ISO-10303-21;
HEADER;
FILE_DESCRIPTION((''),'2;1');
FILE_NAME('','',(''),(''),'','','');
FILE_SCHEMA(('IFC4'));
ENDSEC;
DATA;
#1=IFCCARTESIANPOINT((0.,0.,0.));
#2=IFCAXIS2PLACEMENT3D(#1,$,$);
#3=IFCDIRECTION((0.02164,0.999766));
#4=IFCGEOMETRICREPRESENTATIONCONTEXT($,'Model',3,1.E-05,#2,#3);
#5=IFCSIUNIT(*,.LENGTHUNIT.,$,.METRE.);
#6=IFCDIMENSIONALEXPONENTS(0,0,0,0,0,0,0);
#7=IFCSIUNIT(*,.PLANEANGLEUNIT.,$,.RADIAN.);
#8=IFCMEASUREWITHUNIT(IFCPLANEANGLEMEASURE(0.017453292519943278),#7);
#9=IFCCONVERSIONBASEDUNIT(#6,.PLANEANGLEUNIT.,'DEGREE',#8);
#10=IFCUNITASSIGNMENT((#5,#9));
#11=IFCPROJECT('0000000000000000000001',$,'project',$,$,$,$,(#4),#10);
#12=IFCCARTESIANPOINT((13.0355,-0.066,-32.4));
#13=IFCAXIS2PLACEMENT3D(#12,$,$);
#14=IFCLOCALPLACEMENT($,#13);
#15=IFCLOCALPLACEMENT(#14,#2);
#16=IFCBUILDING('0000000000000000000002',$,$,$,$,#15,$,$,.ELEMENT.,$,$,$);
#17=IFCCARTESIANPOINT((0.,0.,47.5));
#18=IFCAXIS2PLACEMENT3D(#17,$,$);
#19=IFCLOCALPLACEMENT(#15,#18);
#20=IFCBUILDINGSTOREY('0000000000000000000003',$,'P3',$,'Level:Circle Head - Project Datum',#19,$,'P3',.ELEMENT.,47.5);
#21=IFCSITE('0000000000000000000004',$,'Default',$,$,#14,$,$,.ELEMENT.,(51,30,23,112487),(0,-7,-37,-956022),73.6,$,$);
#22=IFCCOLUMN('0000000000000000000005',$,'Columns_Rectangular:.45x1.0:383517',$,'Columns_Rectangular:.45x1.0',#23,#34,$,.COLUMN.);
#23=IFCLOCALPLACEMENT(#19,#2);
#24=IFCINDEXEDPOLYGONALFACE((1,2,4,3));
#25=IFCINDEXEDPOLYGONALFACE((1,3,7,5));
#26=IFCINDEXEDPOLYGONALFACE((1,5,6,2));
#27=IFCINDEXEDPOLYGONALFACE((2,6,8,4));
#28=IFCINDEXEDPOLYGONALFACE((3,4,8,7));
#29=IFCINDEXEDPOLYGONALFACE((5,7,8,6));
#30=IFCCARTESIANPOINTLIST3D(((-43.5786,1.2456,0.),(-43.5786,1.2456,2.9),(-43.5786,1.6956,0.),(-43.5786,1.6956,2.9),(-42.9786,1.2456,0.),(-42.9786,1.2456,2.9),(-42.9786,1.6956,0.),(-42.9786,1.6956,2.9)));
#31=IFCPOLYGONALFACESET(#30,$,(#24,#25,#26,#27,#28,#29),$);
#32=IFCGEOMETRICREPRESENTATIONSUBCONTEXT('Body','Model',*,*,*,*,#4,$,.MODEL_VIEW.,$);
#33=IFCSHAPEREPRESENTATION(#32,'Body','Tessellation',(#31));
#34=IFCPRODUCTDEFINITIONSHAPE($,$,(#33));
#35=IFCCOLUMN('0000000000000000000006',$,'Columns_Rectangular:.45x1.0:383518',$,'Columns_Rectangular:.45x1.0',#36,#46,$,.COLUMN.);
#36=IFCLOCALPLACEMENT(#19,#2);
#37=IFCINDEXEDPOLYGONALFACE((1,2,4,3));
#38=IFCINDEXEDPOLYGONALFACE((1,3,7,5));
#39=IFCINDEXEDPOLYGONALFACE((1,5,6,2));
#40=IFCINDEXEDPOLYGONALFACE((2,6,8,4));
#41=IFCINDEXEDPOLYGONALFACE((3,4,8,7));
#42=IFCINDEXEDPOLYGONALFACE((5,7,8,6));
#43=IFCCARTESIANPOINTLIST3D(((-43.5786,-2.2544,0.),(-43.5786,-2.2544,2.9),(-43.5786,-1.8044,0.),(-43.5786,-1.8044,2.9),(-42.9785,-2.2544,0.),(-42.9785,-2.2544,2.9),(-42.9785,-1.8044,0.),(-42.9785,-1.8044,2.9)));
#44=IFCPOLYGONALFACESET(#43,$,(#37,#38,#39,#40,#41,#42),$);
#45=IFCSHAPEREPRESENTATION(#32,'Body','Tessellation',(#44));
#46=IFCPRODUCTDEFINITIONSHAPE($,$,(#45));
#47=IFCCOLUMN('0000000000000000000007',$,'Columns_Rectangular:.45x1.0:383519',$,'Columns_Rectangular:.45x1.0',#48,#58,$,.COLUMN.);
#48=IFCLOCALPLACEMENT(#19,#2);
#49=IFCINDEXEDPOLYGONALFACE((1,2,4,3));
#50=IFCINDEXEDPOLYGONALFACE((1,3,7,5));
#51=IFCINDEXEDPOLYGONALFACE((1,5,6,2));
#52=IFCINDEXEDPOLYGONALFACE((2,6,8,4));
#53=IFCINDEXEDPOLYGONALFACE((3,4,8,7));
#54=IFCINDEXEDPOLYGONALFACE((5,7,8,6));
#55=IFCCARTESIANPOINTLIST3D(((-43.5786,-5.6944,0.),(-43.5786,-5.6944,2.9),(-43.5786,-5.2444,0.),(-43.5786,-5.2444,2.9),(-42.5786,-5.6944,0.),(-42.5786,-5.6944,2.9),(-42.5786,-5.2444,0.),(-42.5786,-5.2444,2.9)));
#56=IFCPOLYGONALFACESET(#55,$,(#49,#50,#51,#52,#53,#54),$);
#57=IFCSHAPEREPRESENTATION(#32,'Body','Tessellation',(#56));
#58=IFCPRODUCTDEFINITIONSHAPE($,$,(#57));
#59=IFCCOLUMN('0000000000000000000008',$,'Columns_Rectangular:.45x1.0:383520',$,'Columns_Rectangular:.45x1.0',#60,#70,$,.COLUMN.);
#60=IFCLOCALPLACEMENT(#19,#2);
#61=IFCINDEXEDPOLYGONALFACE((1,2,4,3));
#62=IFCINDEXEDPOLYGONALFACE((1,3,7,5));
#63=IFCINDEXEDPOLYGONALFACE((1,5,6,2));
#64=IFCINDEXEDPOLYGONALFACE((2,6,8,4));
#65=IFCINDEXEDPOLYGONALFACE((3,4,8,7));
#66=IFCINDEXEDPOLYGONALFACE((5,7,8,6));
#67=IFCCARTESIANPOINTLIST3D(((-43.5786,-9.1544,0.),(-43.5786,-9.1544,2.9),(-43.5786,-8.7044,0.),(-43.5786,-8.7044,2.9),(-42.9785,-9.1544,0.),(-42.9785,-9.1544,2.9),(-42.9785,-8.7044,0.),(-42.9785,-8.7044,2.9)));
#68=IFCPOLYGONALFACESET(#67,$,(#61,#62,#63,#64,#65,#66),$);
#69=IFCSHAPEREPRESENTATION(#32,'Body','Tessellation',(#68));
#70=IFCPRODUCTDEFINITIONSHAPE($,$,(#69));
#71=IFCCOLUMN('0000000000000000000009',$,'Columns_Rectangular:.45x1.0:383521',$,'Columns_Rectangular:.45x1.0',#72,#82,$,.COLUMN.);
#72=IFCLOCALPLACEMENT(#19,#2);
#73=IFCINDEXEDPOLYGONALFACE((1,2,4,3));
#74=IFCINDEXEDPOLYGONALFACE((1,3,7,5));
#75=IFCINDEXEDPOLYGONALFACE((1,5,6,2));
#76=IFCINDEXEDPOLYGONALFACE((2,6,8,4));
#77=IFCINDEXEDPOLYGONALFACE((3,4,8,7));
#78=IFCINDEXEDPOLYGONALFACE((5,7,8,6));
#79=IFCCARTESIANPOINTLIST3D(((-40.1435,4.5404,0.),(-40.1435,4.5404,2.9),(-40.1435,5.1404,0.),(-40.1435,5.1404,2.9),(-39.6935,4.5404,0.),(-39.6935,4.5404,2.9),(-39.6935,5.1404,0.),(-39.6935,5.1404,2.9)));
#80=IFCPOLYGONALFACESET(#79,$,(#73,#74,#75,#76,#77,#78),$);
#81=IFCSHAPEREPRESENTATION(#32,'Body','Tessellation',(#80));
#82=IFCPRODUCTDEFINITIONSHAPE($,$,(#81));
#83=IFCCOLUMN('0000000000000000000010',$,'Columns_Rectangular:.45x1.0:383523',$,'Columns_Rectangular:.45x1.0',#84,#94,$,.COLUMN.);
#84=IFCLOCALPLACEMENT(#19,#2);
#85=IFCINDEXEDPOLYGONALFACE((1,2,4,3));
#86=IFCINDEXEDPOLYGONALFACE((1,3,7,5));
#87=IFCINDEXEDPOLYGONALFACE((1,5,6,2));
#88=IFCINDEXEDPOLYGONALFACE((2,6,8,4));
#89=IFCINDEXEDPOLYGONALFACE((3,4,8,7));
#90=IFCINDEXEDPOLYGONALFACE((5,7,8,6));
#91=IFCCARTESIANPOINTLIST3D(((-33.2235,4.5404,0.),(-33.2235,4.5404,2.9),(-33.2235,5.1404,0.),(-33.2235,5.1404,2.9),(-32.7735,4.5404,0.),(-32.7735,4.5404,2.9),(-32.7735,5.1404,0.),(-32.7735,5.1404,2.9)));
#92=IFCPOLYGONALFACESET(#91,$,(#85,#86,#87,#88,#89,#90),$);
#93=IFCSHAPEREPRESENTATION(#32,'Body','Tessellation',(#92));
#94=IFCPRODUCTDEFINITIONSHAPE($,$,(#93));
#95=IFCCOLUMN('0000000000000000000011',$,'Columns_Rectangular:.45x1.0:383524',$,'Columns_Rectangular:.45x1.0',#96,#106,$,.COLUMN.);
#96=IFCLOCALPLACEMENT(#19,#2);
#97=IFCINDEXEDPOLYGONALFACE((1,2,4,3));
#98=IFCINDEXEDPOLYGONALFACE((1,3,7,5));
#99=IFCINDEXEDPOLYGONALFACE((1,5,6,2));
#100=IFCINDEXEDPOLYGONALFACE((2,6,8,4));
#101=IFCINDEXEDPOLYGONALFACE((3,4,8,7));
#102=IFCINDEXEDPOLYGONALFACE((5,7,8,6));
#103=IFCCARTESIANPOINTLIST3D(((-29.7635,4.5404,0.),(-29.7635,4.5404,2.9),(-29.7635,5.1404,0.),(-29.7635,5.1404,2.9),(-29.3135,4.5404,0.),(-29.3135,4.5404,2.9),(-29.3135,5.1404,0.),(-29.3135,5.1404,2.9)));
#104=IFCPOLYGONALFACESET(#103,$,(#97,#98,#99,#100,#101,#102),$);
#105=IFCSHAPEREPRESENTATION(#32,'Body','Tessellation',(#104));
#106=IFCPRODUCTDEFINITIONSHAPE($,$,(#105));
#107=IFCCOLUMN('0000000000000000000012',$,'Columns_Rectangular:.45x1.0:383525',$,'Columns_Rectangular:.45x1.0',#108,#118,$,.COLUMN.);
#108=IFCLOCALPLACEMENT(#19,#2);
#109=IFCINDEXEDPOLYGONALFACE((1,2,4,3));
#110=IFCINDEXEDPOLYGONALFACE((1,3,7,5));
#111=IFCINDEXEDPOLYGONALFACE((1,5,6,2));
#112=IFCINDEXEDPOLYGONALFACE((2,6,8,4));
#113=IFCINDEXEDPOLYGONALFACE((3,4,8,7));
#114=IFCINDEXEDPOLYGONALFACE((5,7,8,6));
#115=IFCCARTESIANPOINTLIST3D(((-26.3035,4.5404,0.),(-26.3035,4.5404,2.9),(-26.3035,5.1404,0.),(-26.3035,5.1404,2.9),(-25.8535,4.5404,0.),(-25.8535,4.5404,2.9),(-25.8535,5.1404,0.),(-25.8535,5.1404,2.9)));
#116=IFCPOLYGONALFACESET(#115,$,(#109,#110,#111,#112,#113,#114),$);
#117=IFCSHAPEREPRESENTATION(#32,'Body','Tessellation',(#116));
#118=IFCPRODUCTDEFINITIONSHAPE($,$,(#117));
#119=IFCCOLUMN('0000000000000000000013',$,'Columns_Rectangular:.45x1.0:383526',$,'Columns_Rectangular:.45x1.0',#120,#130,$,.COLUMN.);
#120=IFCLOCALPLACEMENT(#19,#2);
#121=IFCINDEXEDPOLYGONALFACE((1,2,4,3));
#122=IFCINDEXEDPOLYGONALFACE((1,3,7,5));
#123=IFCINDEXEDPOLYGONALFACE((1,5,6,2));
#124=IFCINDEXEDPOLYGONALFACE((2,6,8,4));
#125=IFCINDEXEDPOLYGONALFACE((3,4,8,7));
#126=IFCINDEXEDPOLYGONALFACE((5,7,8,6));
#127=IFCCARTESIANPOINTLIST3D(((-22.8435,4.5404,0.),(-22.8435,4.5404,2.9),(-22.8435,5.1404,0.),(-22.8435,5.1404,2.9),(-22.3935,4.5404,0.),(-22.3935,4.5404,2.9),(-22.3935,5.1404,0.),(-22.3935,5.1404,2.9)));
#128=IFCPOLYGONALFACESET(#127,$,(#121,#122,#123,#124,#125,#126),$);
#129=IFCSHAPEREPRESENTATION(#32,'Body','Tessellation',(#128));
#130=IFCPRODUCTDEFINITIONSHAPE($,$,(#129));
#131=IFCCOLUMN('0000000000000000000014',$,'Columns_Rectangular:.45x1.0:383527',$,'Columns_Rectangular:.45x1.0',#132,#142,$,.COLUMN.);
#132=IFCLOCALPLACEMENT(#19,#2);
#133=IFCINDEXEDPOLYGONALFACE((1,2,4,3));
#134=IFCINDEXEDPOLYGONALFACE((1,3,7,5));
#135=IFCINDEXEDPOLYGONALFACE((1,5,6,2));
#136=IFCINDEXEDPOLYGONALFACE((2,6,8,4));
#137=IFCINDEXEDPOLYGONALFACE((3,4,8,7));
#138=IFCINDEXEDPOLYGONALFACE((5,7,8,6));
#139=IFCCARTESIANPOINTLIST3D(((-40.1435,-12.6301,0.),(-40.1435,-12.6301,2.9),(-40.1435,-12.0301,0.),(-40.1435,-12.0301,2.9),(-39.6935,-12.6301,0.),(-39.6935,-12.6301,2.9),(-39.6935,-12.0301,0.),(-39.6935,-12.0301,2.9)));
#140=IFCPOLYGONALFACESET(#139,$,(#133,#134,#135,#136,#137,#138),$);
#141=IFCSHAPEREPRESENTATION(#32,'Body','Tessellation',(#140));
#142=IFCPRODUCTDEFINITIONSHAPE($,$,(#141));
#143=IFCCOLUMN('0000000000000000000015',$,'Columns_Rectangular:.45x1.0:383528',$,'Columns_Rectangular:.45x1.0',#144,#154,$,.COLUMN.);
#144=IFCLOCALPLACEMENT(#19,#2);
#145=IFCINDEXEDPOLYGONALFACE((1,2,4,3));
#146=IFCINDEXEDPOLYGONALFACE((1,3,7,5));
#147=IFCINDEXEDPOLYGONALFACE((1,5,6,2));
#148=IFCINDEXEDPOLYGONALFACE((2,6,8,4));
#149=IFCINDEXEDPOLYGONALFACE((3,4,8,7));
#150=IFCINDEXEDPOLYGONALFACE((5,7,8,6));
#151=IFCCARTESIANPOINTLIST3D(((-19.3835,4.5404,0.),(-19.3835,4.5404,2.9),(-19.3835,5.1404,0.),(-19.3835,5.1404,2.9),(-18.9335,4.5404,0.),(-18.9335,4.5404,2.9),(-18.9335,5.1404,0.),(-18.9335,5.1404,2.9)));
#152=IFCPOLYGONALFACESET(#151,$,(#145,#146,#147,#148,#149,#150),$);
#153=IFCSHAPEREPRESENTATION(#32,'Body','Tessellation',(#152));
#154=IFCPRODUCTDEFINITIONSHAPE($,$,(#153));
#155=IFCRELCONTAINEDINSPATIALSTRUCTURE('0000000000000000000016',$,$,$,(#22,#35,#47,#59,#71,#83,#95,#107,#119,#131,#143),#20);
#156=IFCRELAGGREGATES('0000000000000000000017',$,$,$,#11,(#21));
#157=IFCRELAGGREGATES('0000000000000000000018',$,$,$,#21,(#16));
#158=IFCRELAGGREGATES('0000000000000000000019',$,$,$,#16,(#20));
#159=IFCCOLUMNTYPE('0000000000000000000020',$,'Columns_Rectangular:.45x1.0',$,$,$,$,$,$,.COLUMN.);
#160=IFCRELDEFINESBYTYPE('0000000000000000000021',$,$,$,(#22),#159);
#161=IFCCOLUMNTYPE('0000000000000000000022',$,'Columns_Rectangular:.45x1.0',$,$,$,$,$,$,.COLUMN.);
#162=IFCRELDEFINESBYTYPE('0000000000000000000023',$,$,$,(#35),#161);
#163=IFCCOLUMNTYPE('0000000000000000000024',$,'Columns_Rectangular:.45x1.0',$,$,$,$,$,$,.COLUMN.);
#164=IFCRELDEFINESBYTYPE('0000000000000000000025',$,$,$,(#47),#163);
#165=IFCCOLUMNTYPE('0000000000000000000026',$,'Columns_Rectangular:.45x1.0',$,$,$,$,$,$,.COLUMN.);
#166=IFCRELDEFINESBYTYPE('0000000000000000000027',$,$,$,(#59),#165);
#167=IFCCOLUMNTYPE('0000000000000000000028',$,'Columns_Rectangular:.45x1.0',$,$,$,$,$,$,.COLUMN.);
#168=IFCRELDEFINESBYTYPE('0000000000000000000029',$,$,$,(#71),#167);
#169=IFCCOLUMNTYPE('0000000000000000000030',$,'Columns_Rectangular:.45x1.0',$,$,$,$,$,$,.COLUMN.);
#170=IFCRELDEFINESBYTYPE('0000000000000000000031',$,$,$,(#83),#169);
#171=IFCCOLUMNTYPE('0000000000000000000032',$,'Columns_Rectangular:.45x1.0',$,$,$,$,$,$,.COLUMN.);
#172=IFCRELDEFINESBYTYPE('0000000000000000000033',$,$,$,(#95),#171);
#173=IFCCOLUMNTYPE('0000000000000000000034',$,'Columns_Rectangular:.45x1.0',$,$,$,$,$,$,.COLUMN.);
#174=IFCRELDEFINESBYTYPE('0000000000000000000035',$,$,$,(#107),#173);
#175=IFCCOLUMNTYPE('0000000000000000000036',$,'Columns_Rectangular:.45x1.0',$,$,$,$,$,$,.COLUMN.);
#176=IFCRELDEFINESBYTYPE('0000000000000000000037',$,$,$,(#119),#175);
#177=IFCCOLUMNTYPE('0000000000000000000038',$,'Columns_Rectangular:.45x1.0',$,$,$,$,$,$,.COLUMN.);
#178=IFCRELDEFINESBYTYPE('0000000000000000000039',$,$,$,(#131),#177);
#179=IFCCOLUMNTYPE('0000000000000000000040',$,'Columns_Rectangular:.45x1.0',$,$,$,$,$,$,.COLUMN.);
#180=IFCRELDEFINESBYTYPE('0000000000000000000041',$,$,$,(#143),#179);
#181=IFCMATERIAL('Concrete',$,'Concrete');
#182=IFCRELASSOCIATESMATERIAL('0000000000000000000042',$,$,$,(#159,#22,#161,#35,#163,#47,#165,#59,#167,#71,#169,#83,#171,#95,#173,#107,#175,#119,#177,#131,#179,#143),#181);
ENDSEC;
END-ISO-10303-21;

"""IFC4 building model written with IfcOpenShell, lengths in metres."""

from ifc_helpers import new_model, entity, si_unit, converted_unit, direction, frame, origin, place, context, subcontext, project, spatial, indexed_curve, outline, extrude, source, transform, mapped, material, type_object, type_shapes, element, save


model = new_model("IFC4")

# Units and contexts
model_context = context("Model", 3, precision=1e-05, world=origin(), true_north=direction((0.02164, 0.999766)))
body_context = subcontext(model_context, "Body", "Model", "MODEL_VIEW")
ifc_project = project(units=[si_unit("LENGTHUNIT", "METRE"), converted_unit("PLANEANGLEUNIT", "DEGREE", entity("IfcPlaneAngleMeasure", 0.017453292519943278), si_unit("PLANEANGLEUNIT", "RADIAN"), dimensions=[0, 0, 0, 0, 0, 0, 0])], contexts=[model_context])

# Site, building, storey
site_placement = place(None, frame((13.0355, -0.066, -32.4)))
site = spatial("IfcSite", under=ifc_project, at=site_placement, Name="Default", CompositionType="ELEMENT", RefLatitude=(51, 30, 23, 112487), RefLongitude=(0, -7, -37, -956022), RefElevation=73.6)
building_placement = place(site_placement, origin())
building = spatial("IfcBuilding", under=site, at=building_placement, CompositionType="ELEMENT")
storey_placement = place(building_placement, frame((0.0, 0.0, 47.5)))
storey = spatial("IfcBuildingStorey", under=building, at=storey_placement, Name="P3", ObjectType="Level:Circle Head - Project Datum", LongName="P3", CompositionType="ELEMENT", Elevation=47.5)

# Columns
ifc_material = material(Name="Concrete", Category="Concrete")
column_type_1 = type_object("IfcColumnType", Name="Columns_Rectangular:.45x1.0", PredefinedType="COLUMN", material=ifc_material)
shared_shape_1 = source(origin(), body_context, "Body", "SweptSolid", [
    extrude(outline(indexed_curve([(-0.3, -0.225), (0.3, -0.225), (0.3, 0.225), (-0.3, 0.225), (-0.3, -0.225)], self_intersect=False)), frame((-43.2786, 1.4706, 47.5)), (0.0, 0.0, 1.0), 2.9),
])
type_shapes(column_type_1, [shared_shape_1])
column_1_placement = place(storey_placement, frame((0.0, 0.0, -47.5)))
element("IfcColumn", 1, at=column_1_placement, inside=storey, type_object=column_type_1, material=ifc_material, Name="Columns_Rectangular:.45x1.0:383517", ObjectType="Columns_Rectangular:.45x1.0", PredefinedType="COLUMN", context=body_context, shape_type="MappedRepresentation", body=[
    mapped(shared_shape_1, transform((0.0, 0.0, 0.0), scale=1.0)),
])
column_type_2 = type_object("IfcColumnType", Name="Columns_Rectangular:.45x1.0", PredefinedType="COLUMN", material=ifc_material)
shared_shape_2 = source(origin(), body_context, "Body", "SweptSolid", [
    extrude(outline(indexed_curve([(-0.3, -0.225), (0.3, -0.225), (0.3, 0.225), (-0.3, 0.225), (-0.3, -0.225)], self_intersect=False)), frame((-43.2785, -2.0294, 47.5)), (0.0, 0.0, 1.0), 2.9),
])
type_shapes(column_type_2, [shared_shape_2])
column_2_placement = place(storey_placement, frame((0.0, 0.0, -47.5)))
element("IfcColumn", 2, at=column_2_placement, inside=storey, type_object=column_type_2, material=ifc_material, Name="Columns_Rectangular:.45x1.0:383518", ObjectType="Columns_Rectangular:.45x1.0", PredefinedType="COLUMN", context=body_context, shape_type="MappedRepresentation", body=[
    mapped(shared_shape_2, transform((0.0, 0.0, 0.0), scale=1.0)),
])
column_type_3 = type_object("IfcColumnType", Name="Columns_Rectangular:.45x1.0", PredefinedType="COLUMN", material=ifc_material)
shared_shape_3 = source(origin(), body_context, "Body", "SweptSolid", [
    extrude(outline(indexed_curve([(-0.5, -0.225), (0.5, -0.225), (0.5, 0.225), (-0.5, 0.225), (-0.5, -0.225)], self_intersect=False)), frame((-43.0786, -5.4694, 47.5), z_axis=(0.0, 0.0, 1.0), x_axis=(-1.0, 0.0, 0.0)), (0.0, 0.0, 1.0), 2.9),
])
type_shapes(column_type_3, [shared_shape_3])
column_3_placement = place(storey_placement, frame((0.0, 0.0, -47.5)))
element("IfcColumn", 3, at=column_3_placement, inside=storey, type_object=column_type_3, material=ifc_material, Name="Columns_Rectangular:.45x1.0:383519", ObjectType="Columns_Rectangular:.45x1.0", PredefinedType="COLUMN", context=body_context, shape_type="MappedRepresentation", body=[
    mapped(shared_shape_3, transform((0.0, 0.0, 0.0), scale=1.0)),
])
column_type_4 = type_object("IfcColumnType", Name="Columns_Rectangular:.45x1.0", PredefinedType="COLUMN", material=ifc_material)
shared_shape_4 = source(origin(), body_context, "Body", "SweptSolid", [
    extrude(outline(indexed_curve([(-0.3, -0.225), (0.3, -0.225), (0.3, 0.225), (-0.3, 0.225), (-0.3, -0.225)], self_intersect=False)), frame((-43.2785, -8.9294, 47.5)), (0.0, 0.0, 1.0), 2.9),
])
type_shapes(column_type_4, [shared_shape_4])
column_4_placement = place(storey_placement, frame((0.0, 0.0, -47.5)))
element("IfcColumn", 4, at=column_4_placement, inside=storey, type_object=column_type_4, material=ifc_material, Name="Columns_Rectangular:.45x1.0:383520", ObjectType="Columns_Rectangular:.45x1.0", PredefinedType="COLUMN", context=body_context, shape_type="MappedRepresentation", body=[
    mapped(shared_shape_4, transform((0.0, 0.0, 0.0), scale=1.0)),
])
column_type_5 = type_object("IfcColumnType", Name="Columns_Rectangular:.45x1.0", PredefinedType="COLUMN", material=ifc_material)
shared_shape_5 = source(origin(), body_context, "Body", "SweptSolid", [
    extrude(outline(indexed_curve([(-0.3, -0.225), (0.3, -0.225), (0.3, 0.225), (-0.3, 0.225), (-0.3, -0.225)], self_intersect=False)), frame((-39.9185, 4.8404, 47.5), z_axis=(0.0, 0.0, 1.0), x_axis=(0.0, -1.0, 0.0)), (0.0, 0.0, 1.0), 2.9),
])
type_shapes(column_type_5, [shared_shape_5])
column_5_placement = place(storey_placement, frame((0.0, 0.0, -47.5)))
element("IfcColumn", 5, at=column_5_placement, inside=storey, type_object=column_type_5, material=ifc_material, Name="Columns_Rectangular:.45x1.0:383521", ObjectType="Columns_Rectangular:.45x1.0", PredefinedType="COLUMN", context=body_context, shape_type="MappedRepresentation", body=[
    mapped(shared_shape_5, transform((0.0, 0.0, 0.0), scale=1.0)),
])
column_type_6 = type_object("IfcColumnType", Name="Columns_Rectangular:.45x1.0", PredefinedType="COLUMN", material=ifc_material)
shared_shape_6 = source(origin(), body_context, "Body", "SweptSolid", [
    extrude(outline(indexed_curve([(-0.3, -0.225), (0.3, -0.225), (0.3, 0.225), (-0.3, 0.225), (-0.3, -0.225)], self_intersect=False)), frame((-32.9985, 4.8404, 47.5), z_axis=(0.0, 0.0, 1.0), x_axis=(0.0, -1.0, 0.0)), (0.0, 0.0, 1.0), 2.9),
])
type_shapes(column_type_6, [shared_shape_6])
column_6_placement = place(storey_placement, frame((0.0, 0.0, -47.5)))
element("IfcColumn", 6, at=column_6_placement, inside=storey, type_object=column_type_6, material=ifc_material, Name="Columns_Rectangular:.45x1.0:383523", ObjectType="Columns_Rectangular:.45x1.0", PredefinedType="COLUMN", context=body_context, shape_type="MappedRepresentation", body=[
    mapped(shared_shape_6, transform((0.0, 0.0, 0.0), scale=1.0)),
])
column_type_7 = type_object("IfcColumnType", Name="Columns_Rectangular:.45x1.0", PredefinedType="COLUMN", material=ifc_material)
shared_shape_7 = source(origin(), body_context, "Body", "SweptSolid", [
    extrude(outline(indexed_curve([(-0.3, -0.225), (0.3, -0.225), (0.3, 0.225), (-0.3, 0.225), (-0.3, -0.225)], self_intersect=False)), frame((-29.5385, 4.8404, 47.5), z_axis=(0.0, 0.0, 1.0), x_axis=(0.0, -1.0, 0.0)), (0.0, 0.0, 1.0), 2.9),
])
type_shapes(column_type_7, [shared_shape_7])
column_7_placement = place(storey_placement, frame((0.0, 0.0, -47.5)))
element("IfcColumn", 7, at=column_7_placement, inside=storey, type_object=column_type_7, material=ifc_material, Name="Columns_Rectangular:.45x1.0:383524", ObjectType="Columns_Rectangular:.45x1.0", PredefinedType="COLUMN", context=body_context, shape_type="MappedRepresentation", body=[
    mapped(shared_shape_7, transform((0.0, 0.0, 0.0), scale=1.0)),
])
column_type_8 = type_object("IfcColumnType", Name="Columns_Rectangular:.45x1.0", PredefinedType="COLUMN", material=ifc_material)
shared_shape_8 = source(origin(), body_context, "Body", "SweptSolid", [
    extrude(outline(indexed_curve([(-0.3, -0.225), (0.3, -0.225), (0.3, 0.225), (-0.3, 0.225), (-0.3, -0.225)], self_intersect=False)), frame((-26.0785, 4.8404, 47.5), z_axis=(0.0, 0.0, 1.0), x_axis=(0.0, -1.0, 0.0)), (0.0, 0.0, 1.0), 2.9),
])
type_shapes(column_type_8, [shared_shape_8])
column_8_placement = place(storey_placement, frame((0.0, 0.0, -47.5)))
element("IfcColumn", 8, at=column_8_placement, inside=storey, type_object=column_type_8, material=ifc_material, Name="Columns_Rectangular:.45x1.0:383525", ObjectType="Columns_Rectangular:.45x1.0", PredefinedType="COLUMN", context=body_context, shape_type="MappedRepresentation", body=[
    mapped(shared_shape_8, transform((0.0, 0.0, 0.0), scale=1.0)),
])
column_type_9 = type_object("IfcColumnType", Name="Columns_Rectangular:.45x1.0", PredefinedType="COLUMN", material=ifc_material)
shared_shape_9 = source(origin(), body_context, "Body", "SweptSolid", [
    extrude(outline(indexed_curve([(-0.3, -0.225), (0.3, -0.225), (0.3, 0.225), (-0.3, 0.225), (-0.3, -0.225)], self_intersect=False)), frame((-22.6185, 4.8404, 47.5), z_axis=(0.0, 0.0, 1.0), x_axis=(0.0, -1.0, 0.0)), (0.0, 0.0, 1.0), 2.9),
])
type_shapes(column_type_9, [shared_shape_9])
column_9_placement = place(storey_placement, frame((0.0, 0.0, -47.5)))
element("IfcColumn", 9, at=column_9_placement, inside=storey, type_object=column_type_9, material=ifc_material, Name="Columns_Rectangular:.45x1.0:383526", ObjectType="Columns_Rectangular:.45x1.0", PredefinedType="COLUMN", context=body_context, shape_type="MappedRepresentation", body=[
    mapped(shared_shape_9, transform((0.0, 0.0, 0.0), scale=1.0)),
])
column_type_10 = type_object("IfcColumnType", Name="Columns_Rectangular:.45x1.0", PredefinedType="COLUMN", material=ifc_material)
shared_shape_10 = source(origin(), body_context, "Body", "SweptSolid", [
    extrude(outline(indexed_curve([(-0.3, -0.225), (0.3, -0.225), (0.3, 0.225), (-0.3, 0.225), (-0.3, -0.225)], self_intersect=False)), frame((-39.9185, -12.3301, 47.5), z_axis=(0.0, 0.0, 1.0), x_axis=(0.000011, 1.0, 0.0)), (0.0, 0.0, 1.0), 2.9),
])
type_shapes(column_type_10, [shared_shape_10])
column_10_placement = place(storey_placement, frame((0.0, 0.0, -47.5)))
element("IfcColumn", 10, at=column_10_placement, inside=storey, type_object=column_type_10, material=ifc_material, Name="Columns_Rectangular:.45x1.0:383527", ObjectType="Columns_Rectangular:.45x1.0", PredefinedType="COLUMN", context=body_context, shape_type="MappedRepresentation", body=[
    mapped(shared_shape_10, transform((0.0, 0.0, 0.0), scale=1.0)),
])
column_type_11 = type_object("IfcColumnType", Name="Columns_Rectangular:.45x1.0", PredefinedType="COLUMN", material=ifc_material)
shared_shape_11 = source(origin(), body_context, "Body", "SweptSolid", [
    extrude(outline(indexed_curve([(-0.3, -0.225), (0.3, -0.225), (0.3, 0.225), (-0.3, 0.225), (-0.3, -0.225)], self_intersect=False)), frame((-19.1585, 4.8404, 47.5), z_axis=(0.0, 0.0, 1.0), x_axis=(0.0, -1.0, 0.0)), (0.0, 0.0, 1.0), 2.9),
])
type_shapes(column_type_11, [shared_shape_11])
column_11_placement = place(storey_placement, frame((0.0, 0.0, -47.5)))
element("IfcColumn", 11, at=column_11_placement, inside=storey, type_object=column_type_11, material=ifc_material, Name="Columns_Rectangular:.45x1.0:383528", ObjectType="Columns_Rectangular:.45x1.0", PredefinedType="COLUMN", context=body_context, shape_type="MappedRepresentation", body=[
    mapped(shared_shape_11, transform((0.0, 0.0, 0.0), scale=1.0)),
])

save(model, "model.ifc")
